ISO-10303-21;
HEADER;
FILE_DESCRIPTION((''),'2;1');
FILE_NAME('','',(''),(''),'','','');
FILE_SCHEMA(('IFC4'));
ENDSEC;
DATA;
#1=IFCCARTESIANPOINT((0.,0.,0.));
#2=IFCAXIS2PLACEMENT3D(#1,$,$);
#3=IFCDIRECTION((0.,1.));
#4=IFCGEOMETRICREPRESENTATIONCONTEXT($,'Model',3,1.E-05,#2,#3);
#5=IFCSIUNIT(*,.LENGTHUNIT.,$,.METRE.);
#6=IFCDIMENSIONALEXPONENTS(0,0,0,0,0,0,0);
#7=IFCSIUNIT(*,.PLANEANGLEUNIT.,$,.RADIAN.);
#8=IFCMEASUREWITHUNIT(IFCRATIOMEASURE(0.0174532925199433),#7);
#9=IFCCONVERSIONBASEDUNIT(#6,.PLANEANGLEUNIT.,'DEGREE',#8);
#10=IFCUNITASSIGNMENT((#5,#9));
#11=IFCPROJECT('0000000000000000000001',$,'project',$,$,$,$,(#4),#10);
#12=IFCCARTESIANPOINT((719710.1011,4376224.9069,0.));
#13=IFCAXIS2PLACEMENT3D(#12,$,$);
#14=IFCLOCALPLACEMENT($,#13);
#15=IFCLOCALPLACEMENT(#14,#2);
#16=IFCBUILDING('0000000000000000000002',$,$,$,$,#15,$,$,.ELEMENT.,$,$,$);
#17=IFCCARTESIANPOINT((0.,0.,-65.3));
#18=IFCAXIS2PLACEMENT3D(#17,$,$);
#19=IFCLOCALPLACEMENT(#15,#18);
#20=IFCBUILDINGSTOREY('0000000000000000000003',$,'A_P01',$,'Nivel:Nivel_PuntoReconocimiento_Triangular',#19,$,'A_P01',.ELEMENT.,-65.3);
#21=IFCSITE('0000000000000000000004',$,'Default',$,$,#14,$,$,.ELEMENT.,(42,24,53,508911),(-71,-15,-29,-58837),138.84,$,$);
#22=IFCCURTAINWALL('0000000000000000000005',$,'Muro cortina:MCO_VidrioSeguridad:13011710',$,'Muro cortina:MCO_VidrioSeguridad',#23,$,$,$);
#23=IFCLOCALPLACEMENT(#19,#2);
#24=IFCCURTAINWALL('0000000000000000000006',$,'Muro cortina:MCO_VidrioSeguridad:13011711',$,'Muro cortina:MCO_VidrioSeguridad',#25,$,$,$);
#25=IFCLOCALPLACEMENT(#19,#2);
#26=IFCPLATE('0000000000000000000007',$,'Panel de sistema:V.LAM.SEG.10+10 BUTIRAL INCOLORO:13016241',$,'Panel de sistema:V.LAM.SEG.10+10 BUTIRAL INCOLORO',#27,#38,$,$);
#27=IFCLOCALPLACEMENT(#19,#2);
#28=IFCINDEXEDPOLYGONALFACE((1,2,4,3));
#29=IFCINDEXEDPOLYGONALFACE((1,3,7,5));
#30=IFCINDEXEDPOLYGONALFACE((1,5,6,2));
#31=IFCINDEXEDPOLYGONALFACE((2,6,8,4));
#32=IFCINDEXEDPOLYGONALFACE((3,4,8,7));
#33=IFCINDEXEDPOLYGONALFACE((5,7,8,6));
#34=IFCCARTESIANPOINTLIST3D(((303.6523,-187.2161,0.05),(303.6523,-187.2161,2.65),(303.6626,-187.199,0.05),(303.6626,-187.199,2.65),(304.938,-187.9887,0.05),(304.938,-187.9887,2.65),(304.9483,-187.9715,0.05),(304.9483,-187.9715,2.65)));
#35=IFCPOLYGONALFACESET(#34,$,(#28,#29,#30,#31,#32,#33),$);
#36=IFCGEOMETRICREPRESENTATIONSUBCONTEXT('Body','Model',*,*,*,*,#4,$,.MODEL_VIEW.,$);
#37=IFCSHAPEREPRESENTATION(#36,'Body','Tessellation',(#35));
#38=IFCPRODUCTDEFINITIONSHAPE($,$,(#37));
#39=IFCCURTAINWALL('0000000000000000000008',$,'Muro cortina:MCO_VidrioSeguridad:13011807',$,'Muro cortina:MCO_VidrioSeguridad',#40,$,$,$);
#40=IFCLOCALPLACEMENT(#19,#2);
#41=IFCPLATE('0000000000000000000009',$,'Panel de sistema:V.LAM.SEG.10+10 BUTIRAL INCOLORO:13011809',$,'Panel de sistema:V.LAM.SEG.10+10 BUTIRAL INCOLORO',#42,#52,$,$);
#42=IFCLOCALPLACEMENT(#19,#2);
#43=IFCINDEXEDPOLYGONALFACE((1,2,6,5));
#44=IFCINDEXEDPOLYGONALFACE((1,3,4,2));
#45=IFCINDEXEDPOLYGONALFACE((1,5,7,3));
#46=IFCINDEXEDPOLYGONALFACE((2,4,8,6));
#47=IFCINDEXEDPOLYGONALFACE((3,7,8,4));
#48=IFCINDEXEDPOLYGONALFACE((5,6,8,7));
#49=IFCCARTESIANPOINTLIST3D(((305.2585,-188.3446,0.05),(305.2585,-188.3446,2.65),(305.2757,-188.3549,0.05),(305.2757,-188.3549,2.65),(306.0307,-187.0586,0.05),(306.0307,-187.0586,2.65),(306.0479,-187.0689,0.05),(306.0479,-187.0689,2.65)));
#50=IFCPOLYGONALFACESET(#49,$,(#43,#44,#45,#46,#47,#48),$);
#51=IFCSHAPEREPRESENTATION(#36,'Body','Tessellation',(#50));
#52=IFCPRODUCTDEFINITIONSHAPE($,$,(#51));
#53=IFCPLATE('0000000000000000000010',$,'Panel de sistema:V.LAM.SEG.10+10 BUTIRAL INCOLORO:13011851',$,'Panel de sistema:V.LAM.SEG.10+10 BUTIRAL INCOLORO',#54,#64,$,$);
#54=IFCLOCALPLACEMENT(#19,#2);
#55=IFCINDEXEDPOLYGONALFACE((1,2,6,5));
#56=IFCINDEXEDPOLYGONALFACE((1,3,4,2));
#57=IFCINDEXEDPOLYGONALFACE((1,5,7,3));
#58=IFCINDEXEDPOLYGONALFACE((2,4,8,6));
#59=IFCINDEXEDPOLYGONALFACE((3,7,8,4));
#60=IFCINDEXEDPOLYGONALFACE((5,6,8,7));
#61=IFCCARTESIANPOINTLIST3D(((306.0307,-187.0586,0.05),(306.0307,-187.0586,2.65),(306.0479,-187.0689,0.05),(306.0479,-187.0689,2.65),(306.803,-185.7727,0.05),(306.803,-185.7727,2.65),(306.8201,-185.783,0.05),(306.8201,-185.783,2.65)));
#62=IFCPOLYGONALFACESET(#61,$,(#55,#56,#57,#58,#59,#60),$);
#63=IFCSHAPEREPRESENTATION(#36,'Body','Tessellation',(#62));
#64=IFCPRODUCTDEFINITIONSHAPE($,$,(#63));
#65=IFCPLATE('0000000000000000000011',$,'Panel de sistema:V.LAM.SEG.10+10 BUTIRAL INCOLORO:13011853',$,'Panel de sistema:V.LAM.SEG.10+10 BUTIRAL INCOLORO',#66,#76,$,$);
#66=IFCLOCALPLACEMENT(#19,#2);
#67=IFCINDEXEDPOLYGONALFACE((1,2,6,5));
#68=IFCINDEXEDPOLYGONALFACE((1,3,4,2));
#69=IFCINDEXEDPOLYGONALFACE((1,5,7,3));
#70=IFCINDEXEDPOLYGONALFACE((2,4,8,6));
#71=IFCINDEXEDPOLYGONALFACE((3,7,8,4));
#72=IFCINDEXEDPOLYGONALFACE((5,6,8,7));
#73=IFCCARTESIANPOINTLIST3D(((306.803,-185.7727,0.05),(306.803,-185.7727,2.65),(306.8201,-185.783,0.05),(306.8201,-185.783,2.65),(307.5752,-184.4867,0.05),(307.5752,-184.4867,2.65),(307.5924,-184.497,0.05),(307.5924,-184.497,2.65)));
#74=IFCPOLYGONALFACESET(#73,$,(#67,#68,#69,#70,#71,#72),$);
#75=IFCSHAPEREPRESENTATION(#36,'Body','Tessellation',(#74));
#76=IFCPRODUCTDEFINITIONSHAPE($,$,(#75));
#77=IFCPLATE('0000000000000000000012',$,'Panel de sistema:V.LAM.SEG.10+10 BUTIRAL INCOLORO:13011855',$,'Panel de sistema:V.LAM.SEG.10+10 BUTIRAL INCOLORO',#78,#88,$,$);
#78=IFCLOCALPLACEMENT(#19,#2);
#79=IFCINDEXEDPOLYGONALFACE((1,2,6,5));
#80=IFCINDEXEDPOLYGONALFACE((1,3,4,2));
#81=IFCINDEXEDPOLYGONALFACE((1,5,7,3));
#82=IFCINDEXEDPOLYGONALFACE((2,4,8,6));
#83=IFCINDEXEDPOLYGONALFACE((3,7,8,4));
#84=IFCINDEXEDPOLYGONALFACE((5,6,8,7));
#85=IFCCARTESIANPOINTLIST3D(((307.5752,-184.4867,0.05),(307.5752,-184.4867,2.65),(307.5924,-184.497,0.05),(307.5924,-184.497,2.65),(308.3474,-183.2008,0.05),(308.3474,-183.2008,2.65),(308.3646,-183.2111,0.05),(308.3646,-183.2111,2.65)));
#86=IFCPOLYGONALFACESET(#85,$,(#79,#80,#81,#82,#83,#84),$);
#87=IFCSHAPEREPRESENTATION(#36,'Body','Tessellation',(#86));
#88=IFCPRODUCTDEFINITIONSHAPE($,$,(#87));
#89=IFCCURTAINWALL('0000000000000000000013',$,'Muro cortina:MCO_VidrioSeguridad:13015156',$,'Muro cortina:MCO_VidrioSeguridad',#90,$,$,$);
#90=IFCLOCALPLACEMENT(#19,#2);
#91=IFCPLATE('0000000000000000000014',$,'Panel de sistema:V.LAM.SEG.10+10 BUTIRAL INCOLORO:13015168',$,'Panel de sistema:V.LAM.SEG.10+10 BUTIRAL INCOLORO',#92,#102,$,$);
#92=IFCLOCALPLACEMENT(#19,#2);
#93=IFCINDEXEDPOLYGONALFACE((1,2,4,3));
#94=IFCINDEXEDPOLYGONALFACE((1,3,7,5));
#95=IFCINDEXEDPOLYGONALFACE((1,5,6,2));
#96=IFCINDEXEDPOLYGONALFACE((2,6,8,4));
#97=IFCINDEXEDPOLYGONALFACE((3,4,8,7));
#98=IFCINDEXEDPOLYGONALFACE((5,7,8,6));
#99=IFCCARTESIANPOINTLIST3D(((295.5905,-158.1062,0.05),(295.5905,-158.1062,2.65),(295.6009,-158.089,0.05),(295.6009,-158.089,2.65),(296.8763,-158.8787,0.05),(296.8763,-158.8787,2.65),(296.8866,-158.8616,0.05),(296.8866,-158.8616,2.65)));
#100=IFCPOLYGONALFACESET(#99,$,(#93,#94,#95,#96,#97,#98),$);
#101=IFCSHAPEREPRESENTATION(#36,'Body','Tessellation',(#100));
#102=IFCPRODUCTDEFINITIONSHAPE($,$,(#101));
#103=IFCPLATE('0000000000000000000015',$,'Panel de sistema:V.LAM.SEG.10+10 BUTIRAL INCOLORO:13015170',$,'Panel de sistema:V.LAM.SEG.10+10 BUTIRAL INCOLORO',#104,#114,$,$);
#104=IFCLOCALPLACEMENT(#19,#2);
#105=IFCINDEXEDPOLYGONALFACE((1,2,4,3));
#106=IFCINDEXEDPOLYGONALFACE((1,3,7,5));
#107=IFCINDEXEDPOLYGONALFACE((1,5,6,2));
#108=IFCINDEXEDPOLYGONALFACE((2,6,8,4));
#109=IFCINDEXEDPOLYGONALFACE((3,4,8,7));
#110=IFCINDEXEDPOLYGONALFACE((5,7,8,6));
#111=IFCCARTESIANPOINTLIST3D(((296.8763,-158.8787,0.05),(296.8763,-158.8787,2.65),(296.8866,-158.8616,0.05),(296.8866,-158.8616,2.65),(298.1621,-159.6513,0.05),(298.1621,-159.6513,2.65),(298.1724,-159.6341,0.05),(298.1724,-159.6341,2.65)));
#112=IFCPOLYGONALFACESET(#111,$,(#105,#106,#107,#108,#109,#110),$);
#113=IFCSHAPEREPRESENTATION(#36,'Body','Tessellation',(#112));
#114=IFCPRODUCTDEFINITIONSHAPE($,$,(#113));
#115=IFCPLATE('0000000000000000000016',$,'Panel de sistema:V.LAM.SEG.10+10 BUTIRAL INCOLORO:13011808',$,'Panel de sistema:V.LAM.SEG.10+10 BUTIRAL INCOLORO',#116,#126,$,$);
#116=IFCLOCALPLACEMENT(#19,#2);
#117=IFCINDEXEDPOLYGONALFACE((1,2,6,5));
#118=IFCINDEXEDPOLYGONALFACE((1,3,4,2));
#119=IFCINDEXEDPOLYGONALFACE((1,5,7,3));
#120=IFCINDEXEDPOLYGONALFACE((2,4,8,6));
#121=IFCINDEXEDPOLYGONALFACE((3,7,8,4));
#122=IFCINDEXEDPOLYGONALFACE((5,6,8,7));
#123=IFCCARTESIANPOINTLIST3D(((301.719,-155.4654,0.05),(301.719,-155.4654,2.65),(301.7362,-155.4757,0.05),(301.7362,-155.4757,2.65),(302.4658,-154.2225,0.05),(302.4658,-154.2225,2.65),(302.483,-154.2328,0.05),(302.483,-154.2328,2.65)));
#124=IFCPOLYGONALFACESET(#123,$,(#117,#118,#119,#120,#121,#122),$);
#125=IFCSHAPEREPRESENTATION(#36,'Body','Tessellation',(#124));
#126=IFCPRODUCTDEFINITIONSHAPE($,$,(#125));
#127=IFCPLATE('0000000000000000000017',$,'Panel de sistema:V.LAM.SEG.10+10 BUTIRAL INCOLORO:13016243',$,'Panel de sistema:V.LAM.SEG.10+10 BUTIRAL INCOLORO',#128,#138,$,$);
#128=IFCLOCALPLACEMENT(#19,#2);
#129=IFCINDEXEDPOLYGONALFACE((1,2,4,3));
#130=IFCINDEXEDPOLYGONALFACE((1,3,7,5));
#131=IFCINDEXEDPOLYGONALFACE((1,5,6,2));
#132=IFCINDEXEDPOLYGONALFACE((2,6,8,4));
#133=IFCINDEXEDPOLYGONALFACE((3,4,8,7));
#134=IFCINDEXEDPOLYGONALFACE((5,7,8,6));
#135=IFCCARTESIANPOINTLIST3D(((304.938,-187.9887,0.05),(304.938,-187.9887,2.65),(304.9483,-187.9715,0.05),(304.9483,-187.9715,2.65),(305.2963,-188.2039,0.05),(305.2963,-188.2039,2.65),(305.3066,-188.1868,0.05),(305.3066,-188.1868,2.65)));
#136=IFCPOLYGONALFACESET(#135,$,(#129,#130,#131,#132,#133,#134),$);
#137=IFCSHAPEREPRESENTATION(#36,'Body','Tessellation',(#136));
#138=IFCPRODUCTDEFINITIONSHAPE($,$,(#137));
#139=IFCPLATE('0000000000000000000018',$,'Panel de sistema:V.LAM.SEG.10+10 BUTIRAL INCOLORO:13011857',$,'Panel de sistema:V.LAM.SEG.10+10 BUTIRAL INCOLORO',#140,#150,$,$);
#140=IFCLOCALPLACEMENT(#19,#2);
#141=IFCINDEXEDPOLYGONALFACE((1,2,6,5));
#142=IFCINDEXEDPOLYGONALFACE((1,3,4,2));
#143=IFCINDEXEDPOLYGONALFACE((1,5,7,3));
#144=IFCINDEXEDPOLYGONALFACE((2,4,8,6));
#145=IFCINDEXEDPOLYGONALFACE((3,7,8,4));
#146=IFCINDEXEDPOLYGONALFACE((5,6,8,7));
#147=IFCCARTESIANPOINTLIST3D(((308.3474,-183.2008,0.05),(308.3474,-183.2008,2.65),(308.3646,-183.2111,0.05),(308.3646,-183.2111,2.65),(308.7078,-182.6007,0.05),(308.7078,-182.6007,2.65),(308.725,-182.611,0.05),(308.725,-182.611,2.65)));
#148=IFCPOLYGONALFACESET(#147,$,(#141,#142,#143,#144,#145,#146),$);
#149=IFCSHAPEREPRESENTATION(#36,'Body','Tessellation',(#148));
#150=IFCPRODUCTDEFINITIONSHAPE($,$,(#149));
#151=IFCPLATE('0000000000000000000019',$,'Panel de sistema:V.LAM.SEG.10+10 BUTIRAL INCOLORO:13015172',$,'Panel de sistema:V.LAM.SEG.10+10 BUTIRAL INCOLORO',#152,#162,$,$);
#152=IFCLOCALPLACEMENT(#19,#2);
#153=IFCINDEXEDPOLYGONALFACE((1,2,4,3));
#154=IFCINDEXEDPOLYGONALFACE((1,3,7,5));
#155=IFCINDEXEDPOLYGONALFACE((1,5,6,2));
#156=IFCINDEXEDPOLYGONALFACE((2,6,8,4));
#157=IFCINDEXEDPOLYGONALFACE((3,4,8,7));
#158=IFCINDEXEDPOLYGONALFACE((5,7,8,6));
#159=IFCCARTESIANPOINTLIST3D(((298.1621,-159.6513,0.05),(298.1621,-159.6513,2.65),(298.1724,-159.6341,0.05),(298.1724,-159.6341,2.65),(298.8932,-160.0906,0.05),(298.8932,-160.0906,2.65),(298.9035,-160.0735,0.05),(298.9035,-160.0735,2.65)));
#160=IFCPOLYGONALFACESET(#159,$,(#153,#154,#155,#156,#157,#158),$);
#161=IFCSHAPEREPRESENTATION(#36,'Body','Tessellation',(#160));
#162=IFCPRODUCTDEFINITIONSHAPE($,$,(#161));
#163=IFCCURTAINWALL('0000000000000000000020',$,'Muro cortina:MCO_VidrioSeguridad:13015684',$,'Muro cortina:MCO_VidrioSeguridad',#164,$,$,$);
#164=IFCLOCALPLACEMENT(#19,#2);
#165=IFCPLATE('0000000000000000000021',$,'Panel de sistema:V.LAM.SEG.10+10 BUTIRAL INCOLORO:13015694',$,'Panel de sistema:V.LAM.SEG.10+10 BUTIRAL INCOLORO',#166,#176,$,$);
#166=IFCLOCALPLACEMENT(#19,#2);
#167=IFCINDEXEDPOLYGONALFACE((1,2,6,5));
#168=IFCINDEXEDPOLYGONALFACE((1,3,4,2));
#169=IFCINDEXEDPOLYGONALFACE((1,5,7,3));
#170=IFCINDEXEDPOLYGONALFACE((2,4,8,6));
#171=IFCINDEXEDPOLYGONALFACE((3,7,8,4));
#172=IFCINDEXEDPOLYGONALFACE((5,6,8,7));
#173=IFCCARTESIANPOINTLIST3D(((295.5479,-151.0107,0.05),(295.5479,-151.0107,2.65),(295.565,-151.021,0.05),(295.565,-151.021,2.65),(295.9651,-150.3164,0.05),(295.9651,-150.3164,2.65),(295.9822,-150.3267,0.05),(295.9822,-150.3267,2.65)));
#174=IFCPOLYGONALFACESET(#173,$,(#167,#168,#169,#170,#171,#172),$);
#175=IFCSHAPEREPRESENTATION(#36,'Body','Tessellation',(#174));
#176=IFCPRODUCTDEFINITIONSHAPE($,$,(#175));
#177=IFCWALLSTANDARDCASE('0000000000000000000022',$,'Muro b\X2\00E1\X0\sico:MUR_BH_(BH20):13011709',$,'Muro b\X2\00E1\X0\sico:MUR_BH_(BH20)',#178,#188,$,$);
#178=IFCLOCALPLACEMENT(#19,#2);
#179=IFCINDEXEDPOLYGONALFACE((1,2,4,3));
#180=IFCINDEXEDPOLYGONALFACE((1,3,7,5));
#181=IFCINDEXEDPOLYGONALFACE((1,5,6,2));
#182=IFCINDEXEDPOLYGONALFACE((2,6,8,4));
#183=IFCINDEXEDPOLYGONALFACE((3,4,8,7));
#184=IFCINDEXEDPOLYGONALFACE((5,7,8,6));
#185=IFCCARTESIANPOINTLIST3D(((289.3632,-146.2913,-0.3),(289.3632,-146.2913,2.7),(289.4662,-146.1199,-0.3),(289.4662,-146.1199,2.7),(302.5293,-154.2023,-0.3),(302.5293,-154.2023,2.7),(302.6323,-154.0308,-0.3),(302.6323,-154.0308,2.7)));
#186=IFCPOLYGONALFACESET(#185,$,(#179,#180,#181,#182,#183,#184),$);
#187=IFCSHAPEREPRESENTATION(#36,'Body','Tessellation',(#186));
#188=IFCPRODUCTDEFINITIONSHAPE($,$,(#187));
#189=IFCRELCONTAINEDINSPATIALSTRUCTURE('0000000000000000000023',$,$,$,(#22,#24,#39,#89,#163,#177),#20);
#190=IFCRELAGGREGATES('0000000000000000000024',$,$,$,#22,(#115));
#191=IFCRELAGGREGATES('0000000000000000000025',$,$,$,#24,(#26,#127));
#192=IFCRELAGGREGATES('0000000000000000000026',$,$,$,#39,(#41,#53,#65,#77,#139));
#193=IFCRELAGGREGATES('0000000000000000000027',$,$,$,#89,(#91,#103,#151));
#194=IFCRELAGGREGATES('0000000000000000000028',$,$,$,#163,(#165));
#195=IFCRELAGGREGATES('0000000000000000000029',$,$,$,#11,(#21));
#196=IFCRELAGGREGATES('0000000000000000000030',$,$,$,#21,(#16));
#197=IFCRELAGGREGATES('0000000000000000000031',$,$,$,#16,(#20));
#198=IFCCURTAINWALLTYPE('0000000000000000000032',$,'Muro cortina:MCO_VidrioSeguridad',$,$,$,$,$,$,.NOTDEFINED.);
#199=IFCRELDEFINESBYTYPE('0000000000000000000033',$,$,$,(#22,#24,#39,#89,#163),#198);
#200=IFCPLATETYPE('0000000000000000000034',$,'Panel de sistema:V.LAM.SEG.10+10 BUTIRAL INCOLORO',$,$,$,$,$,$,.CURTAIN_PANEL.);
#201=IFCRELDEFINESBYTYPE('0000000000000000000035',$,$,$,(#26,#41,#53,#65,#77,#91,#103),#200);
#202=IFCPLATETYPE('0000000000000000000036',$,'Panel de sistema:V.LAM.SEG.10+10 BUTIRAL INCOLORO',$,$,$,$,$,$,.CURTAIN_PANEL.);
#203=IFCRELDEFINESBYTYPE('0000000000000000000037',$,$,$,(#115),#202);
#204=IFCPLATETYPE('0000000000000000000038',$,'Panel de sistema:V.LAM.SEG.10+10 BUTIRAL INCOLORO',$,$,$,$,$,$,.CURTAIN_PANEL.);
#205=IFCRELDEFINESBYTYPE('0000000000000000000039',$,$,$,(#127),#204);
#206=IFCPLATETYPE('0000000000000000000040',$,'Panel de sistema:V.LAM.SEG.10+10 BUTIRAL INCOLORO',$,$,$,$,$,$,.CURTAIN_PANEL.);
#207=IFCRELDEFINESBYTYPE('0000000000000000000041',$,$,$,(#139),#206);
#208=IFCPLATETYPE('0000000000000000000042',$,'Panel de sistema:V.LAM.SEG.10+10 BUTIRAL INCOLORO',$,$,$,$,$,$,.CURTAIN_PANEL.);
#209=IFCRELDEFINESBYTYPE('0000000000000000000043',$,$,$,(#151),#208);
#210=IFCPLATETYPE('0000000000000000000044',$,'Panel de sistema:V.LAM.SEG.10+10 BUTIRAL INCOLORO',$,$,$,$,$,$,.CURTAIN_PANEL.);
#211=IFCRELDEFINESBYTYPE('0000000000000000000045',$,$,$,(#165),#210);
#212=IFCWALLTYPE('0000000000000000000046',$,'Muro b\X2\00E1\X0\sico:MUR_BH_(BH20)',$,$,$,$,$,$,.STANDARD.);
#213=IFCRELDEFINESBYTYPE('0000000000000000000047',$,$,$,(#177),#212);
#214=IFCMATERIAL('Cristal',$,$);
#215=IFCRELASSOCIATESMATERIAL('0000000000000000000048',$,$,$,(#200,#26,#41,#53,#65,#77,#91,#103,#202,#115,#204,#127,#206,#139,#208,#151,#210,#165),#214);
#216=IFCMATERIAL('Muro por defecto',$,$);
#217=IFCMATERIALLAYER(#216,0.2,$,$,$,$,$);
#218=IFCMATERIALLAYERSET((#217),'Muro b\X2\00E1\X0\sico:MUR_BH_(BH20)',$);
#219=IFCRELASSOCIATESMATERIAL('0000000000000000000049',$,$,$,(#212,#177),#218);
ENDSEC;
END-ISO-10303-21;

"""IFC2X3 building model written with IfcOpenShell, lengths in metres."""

from ifc_helpers import new_model, entity, si_unit, converted_unit, direction, frame, frame_2d, origin, origin_2d_with_axis, place, context, subcontext, project, spatial, rectangle, extrude, source, transform, mapped, material, layer, layer_set, layer_usage, type_object, type_shapes, element, aggregate, save


model = new_model("IFC2X3")

# Units and contexts
model_context = context("Model", 3, precision=1e-05, world=origin(), true_north=direction((0.0, 1.0)))
body_context = subcontext(model_context, "Body", "Model", "MODEL_VIEW")
ifc_project = project(units=[si_unit("LENGTHUNIT", "METRE"), converted_unit("PLANEANGLEUNIT", "DEGREE", entity("IfcRatioMeasure", 0.0174532925199433), si_unit("PLANEANGLEUNIT", "RADIAN"), dimensions=[0, 0, 0, 0, 0, 0, 0])], contexts=[model_context])

# Site, building, storey
site_placement = place(None, frame((719710.1011, 4376224.9069, 0.0)))
site = spatial("IfcSite", under=ifc_project, at=site_placement, Name="Default", CompositionType="ELEMENT", RefLatitude=(42, 24, 53, 508911), RefLongitude=(-71, -15, -29, -58837), RefElevation=138.84)
building_placement = place(site_placement, origin())
building = spatial("IfcBuilding", under=site, at=building_placement, CompositionType="ELEMENT")
storey_placement = place(building_placement, frame((0.0, 0.0, -65.3)))
storey = spatial("IfcBuildingStorey", under=building, at=storey_placement, Name="A_P01", ObjectType="Nivel:Nivel_PuntoReconocimiento_Triangular", LongName="A_P01", CompositionType="ELEMENT", Elevation=-65.3)

# Curtain walls, plates
curtain_wall_type = type_object("IfcCurtainWallType", Name="Muro cortina:MCO_VidrioSeguridad", PredefinedType="NOTDEFINED")
curtain_wall_1_placement = place(storey_placement, frame((0.0, 0.0, 65.3)))
curtain_wall_1 = element("IfcCurtainWall", 1, at=curtain_wall_1_placement, inside=storey, type_object=curtain_wall_type, Name="Muro cortina:MCO_VidrioSeguridad:13011710", ObjectType="Muro cortina:MCO_VidrioSeguridad")
ifc_material_1 = material(Name="Cristal")
plate_type_1 = type_object("IfcPlateType", Name="Panel de sistema:V.LAM.SEG.10+10 BUTIRAL INCOLORO", PredefinedType="CURTAIN_PANEL", material=ifc_material_1)
shared_shape_1 = source(origin(), body_context, "Body", "SweptSolid", [
    extrude(rectangle(XDim=0.02, YDim=1.5, at=origin_2d_with_axis()), frame((0.0, 0.0, 0.0), z_axis=(0.0, 0.0, 1.0), x_axis=(0.0, 1.0, 0.0)), (0.0, 0.0, 1.0), 2.6),
])
type_shapes(plate_type_1, [shared_shape_1])
curtain_wall_2_placement = place(storey_placement, frame((0.0, 0.0, 65.3)))
curtain_wall_2 = element("IfcCurtainWall", 2, at=curtain_wall_2_placement, inside=storey, type_object=curtain_wall_type, Name="Muro cortina:MCO_VidrioSeguridad:13011711", ObjectType="Muro cortina:MCO_VidrioSeguridad")
plate_1_placement = place(curtain_wall_2_placement, frame((304.3003, -187.5938, -65.25), z_axis=(0.0, 0.0, 1.0), x_axis=(0.857167, -0.515038, 0.0)))
plate_1 = element("IfcPlate", 3, at=plate_1_placement, type_object=plate_type_1, material=ifc_material_1, Name="Panel de sistema:V.LAM.SEG.10+10 BUTIRAL INCOLORO:13016241", ObjectType="Panel de sistema:V.LAM.SEG.10+10 BUTIRAL INCOLORO", context=body_context, shape_type="MappedRepresentation", body=[
    mapped(shared_shape_1, transform((0.0, 0.0, 0.0), scale=1.0)),
])
curtain_wall_3_placement = place(storey_placement, frame((0.0, 0.0, 65.3)))
curtain_wall_3 = element("IfcCurtainWall", 4, at=curtain_wall_3_placement, inside=storey, type_object=curtain_wall_type, Name="Muro cortina:MCO_VidrioSeguridad:13011807", ObjectType="Muro cortina:MCO_VidrioSeguridad")
plate_2_placement = place(curtain_wall_3_placement, frame((305.6532, -187.7067, -65.25), z_axis=(0.0, 0.0, 1.0), x_axis=(0.514822, 0.857297, 0.0)))
plate_2 = element("IfcPlate", 5, at=plate_2_placement, type_object=plate_type_1, material=ifc_material_1, Name="Panel de sistema:V.LAM.SEG.10+10 BUTIRAL INCOLORO:13011809", ObjectType="Panel de sistema:V.LAM.SEG.10+10 BUTIRAL INCOLORO", context=body_context, shape_type="MappedRepresentation", body=[
    mapped(shared_shape_1, transform((0.0, 0.0, 0.0), scale=1.0)),
])
plate_3_placement = place(curtain_wall_3_placement, frame((306.4254, -186.4208, -65.25), z_axis=(0.0, 0.0, 1.0), x_axis=(0.514822, 0.857297, 0.0)))
plate_3 = element("IfcPlate", 6, at=plate_3_placement, type_object=plate_type_1, material=ifc_material_1, Name="Panel de sistema:V.LAM.SEG.10+10 BUTIRAL INCOLORO:13011851", ObjectType="Panel de sistema:V.LAM.SEG.10+10 BUTIRAL INCOLORO", context=body_context, shape_type="MappedRepresentation", body=[
    mapped(shared_shape_1, transform((0.0, 0.0, 0.0), scale=1.0)),
])
plate_4_placement = place(curtain_wall_3_placement, frame((307.1977, -185.1349, -65.25), z_axis=(0.0, 0.0, 1.0), x_axis=(0.514822, 0.857297, 0.0)))
plate_4 = element("IfcPlate", 7, at=plate_4_placement, type_object=plate_type_1, material=ifc_material_1, Name="Panel de sistema:V.LAM.SEG.10+10 BUTIRAL INCOLORO:13011853", ObjectType="Panel de sistema:V.LAM.SEG.10+10 BUTIRAL INCOLORO", context=body_context, shape_type="MappedRepresentation", body=[
    mapped(shared_shape_1, transform((0.0, 0.0, 0.0), scale=1.0)),
])
plate_5_placement = place(curtain_wall_3_placement, frame((307.9699, -183.8489, -65.25), z_axis=(0.0, 0.0, 1.0), x_axis=(0.514822, 0.857297, 0.0)))
plate_5 = element("IfcPlate", 8, at=plate_5_placement, type_object=plate_type_1, material=ifc_material_1, Name="Panel de sistema:V.LAM.SEG.10+10 BUTIRAL INCOLORO:13011855", ObjectType="Panel de sistema:V.LAM.SEG.10+10 BUTIRAL INCOLORO", context=body_context, shape_type="MappedRepresentation", body=[
    mapped(shared_shape_1, transform((0.0, 0.0, 0.0), scale=1.0)),
])
curtain_wall_4_placement = place(storey_placement, frame((0.0, 0.0, 65.3)))
curtain_wall_4 = element("IfcCurtainWall", 9, at=curtain_wall_4_placement, inside=storey, type_object=curtain_wall_type, Name="Muro cortina:MCO_VidrioSeguridad:13015156", ObjectType="Muro cortina:MCO_VidrioSeguridad")
plate_6_placement = place(curtain_wall_4_placement, frame((296.2386, -158.4839, -65.25), z_axis=(0.0, 0.0, 1.0), x_axis=(0.857167, -0.515038, 0.0)))
plate_6 = element("IfcPlate", 10, at=plate_6_placement, type_object=plate_type_1, material=ifc_material_1, Name="Panel de sistema:V.LAM.SEG.10+10 BUTIRAL INCOLORO:13015168", ObjectType="Panel de sistema:V.LAM.SEG.10+10 BUTIRAL INCOLORO", context=body_context, shape_type="MappedRepresentation", body=[
    mapped(shared_shape_1, transform((0.0, 0.0, 0.0), scale=1.0)),
])
plate_7_placement = place(curtain_wall_4_placement, frame((297.5243, -159.2564, -65.25), z_axis=(0.0, 0.0, 1.0), x_axis=(0.857167, -0.515038, 0.0)))
plate_7 = element("IfcPlate", 11, at=plate_7_placement, type_object=plate_type_1, material=ifc_material_1, Name="Panel de sistema:V.LAM.SEG.10+10 BUTIRAL INCOLORO:13015170", ObjectType="Panel de sistema:V.LAM.SEG.10+10 BUTIRAL INCOLORO", context=body_context, shape_type="MappedRepresentation", body=[
    mapped(shared_shape_1, transform((0.0, 0.0, 0.0), scale=1.0)),
])

# Plates
plate_type_2 = type_object("IfcPlateType", Name="Panel de sistema:V.LAM.SEG.10+10 BUTIRAL INCOLORO", PredefinedType="CURTAIN_PANEL", material=ifc_material_1)
shared_shape_2 = source(origin(), body_context, "Body", "SweptSolid", [
    extrude(rectangle(XDim=0.02, YDim=1.45, at=origin_2d_with_axis()), frame((0.0, 0.0, 0.0), z_axis=(0.0, 0.0, 1.0), x_axis=(0.0, 1.0, 0.0)), (0.0, 0.0, 1.0), 2.6),
])
type_shapes(plate_type_2, [shared_shape_2])
plate_8_placement = place(curtain_wall_1_placement, frame((302.101, -154.8491, -65.25), z_axis=(0.0, 0.0, 1.0), x_axis=(-0.515038, -0.857167, 0.0)))
plate_8 = element("IfcPlate", 12, at=plate_8_placement, type_object=plate_type_2, material=ifc_material_1, Name="Panel de sistema:V.LAM.SEG.10+10 BUTIRAL INCOLORO:13011808", ObjectType="Panel de sistema:V.LAM.SEG.10+10 BUTIRAL INCOLORO", context=body_context, shape_type="MappedRepresentation", body=[
    mapped(shared_shape_2, transform((0.0, 0.0, 0.0), scale=1.0)),
])
aggregate(curtain_wall_1, [plate_8])
plate_type_3 = type_object("IfcPlateType", Name="Panel de sistema:V.LAM.SEG.10+10 BUTIRAL INCOLORO", PredefinedType="CURTAIN_PANEL", material=ifc_material_1)
shared_shape_3 = source(origin(), body_context, "Body", "SweptSolid", [
    extrude(rectangle(XDim=0.02, YDim=0.4179, at=origin_2d_with_axis()), frame((0.0, 0.0, 0.0), z_axis=(0.0, 0.0, 1.0), x_axis=(0.0, 1.0, 0.0)), (0.0, 0.0, 1.0), 2.6),
])
type_shapes(plate_type_3, [shared_shape_3])
plate_9_placement = place(curtain_wall_2_placement, frame((305.1223, -188.0877, -65.25), z_axis=(0.0, 0.0, 1.0), x_axis=(0.857167, -0.515038, 0.0)))
plate_9 = element("IfcPlate", 13, at=plate_9_placement, type_object=plate_type_3, material=ifc_material_1, Name="Panel de sistema:V.LAM.SEG.10+10 BUTIRAL INCOLORO:13016243", ObjectType="Panel de sistema:V.LAM.SEG.10+10 BUTIRAL INCOLORO", context=body_context, shape_type="MappedRepresentation", body=[
    mapped(shared_shape_3, transform((0.0, 0.0, 0.0), scale=1.0)),
])
aggregate(curtain_wall_2, [plate_1, plate_9])
plate_type_4 = type_object("IfcPlateType", Name="Panel de sistema:V.LAM.SEG.10+10 BUTIRAL INCOLORO", PredefinedType="CURTAIN_PANEL", material=ifc_material_1)
shared_shape_4 = source(origin(), body_context, "Body", "SweptSolid", [
    extrude(rectangle(XDim=0.02, YDim=0.7, at=origin_2d_with_axis()), frame((0.0, 0.0, 0.0), z_axis=(0.0, 0.0, 1.0), x_axis=(0.0, 1.0, 0.0)), (0.0, 0.0, 1.0), 2.6),
])
type_shapes(plate_type_4, [shared_shape_4])
plate_10_placement = place(curtain_wall_3_placement, frame((308.5362, -182.9059, -65.25), z_axis=(0.0, 0.0, 1.0), x_axis=(0.514822, 0.857297, 0.0)))
plate_10 = element("IfcPlate", 14, at=plate_10_placement, type_object=plate_type_4, material=ifc_material_1, Name="Panel de sistema:V.LAM.SEG.10+10 BUTIRAL INCOLORO:13011857", ObjectType="Panel de sistema:V.LAM.SEG.10+10 BUTIRAL INCOLORO", context=body_context, shape_type="MappedRepresentation", body=[
    mapped(shared_shape_4, transform((0.0, 0.0, 0.0), scale=1.0)),
])
aggregate(curtain_wall_3, [plate_2, plate_3, plate_4, plate_5, plate_10])
plate_type_5 = type_object("IfcPlateType", Name="Panel de sistema:V.LAM.SEG.10+10 BUTIRAL INCOLORO", PredefinedType="CURTAIN_PANEL", material=ifc_material_1)
shared_shape_5 = source(origin(), body_context, "Body", "SweptSolid", [
    extrude(rectangle(XDim=0.02, YDim=0.853, at=origin_2d_with_axis()), frame((0.0, 0.0, 0.0), z_axis=(0.0, 0.0, 1.0), x_axis=(0.0, 1.0, 0.0)), (0.0, 0.0, 1.0), 2.6),
])
type_shapes(plate_type_5, [shared_shape_5])
plate_11_placement = place(curtain_wall_4_placement, frame((298.5328, -159.8624, -65.25), z_axis=(0.0, 0.0, 1.0), x_axis=(0.857167, -0.515038, 0.0)))
plate_11 = element("IfcPlate", 15, at=plate_11_placement, type_object=plate_type_5, material=ifc_material_1, Name="Panel de sistema:V.LAM.SEG.10+10 BUTIRAL INCOLORO:13015172", ObjectType="Panel de sistema:V.LAM.SEG.10+10 BUTIRAL INCOLORO", context=body_context, shape_type="MappedRepresentation", body=[
    mapped(shared_shape_5, transform((0.0, 0.0, 0.0), scale=1.0)),
])
aggregate(curtain_wall_4, [plate_6, plate_7, plate_11])

# Curtain wall, plate
curtain_wall_5_placement = place(storey_placement, frame((0.0, 0.0, 65.3)))
curtain_wall_5 = element("IfcCurtainWall", 16, at=curtain_wall_5_placement, inside=storey, type_object=curtain_wall_type, Name="Muro cortina:MCO_VidrioSeguridad:13015684", ObjectType="Muro cortina:MCO_VidrioSeguridad")
plate_type_6 = type_object("IfcPlateType", Name="Panel de sistema:V.LAM.SEG.10+10 BUTIRAL INCOLORO", PredefinedType="CURTAIN_PANEL", material=ifc_material_1)
shared_shape_6 = source(origin(), body_context, "Body", "SweptSolid", [
    extrude(rectangle(XDim=0.02, YDim=0.81, at=origin_2d_with_axis()), frame((0.0, 0.0, 0.0), z_axis=(0.0, 0.0, 1.0), x_axis=(0.0, 1.0, 0.0)), (0.0, 0.0, 1.0), 2.6),
])
type_shapes(plate_type_6, [shared_shape_6])
plate_12_placement = place(curtain_wall_5_placement, frame((295.765, -150.6687, -65.25), z_axis=(0.0, 0.0, 1.0), x_axis=(0.515038, 0.857167, 0.0)))
plate_12 = element("IfcPlate", 17, at=plate_12_placement, type_object=plate_type_6, material=ifc_material_1, Name="Panel de sistema:V.LAM.SEG.10+10 BUTIRAL INCOLORO:13015694", ObjectType="Panel de sistema:V.LAM.SEG.10+10 BUTIRAL INCOLORO", context=body_context, shape_type="MappedRepresentation", body=[
    mapped(shared_shape_6, transform((0.0, 0.0, 0.0), scale=1.0)),
])
aggregate(curtain_wall_5, [plate_12])

# Wall
ifc_material_2 = material(Name="Muro por defecto")
ifc_layer = layer(ifc_material_2, 0.2)
ifc_layer_set = layer_set([ifc_layer], Name="Muro básico:MUR_BH_(BH20)")
ifc_layer_usage_1 = layer_usage(ifc_layer_set, "AXIS2", "NEGATIVE", 0.1)
wall_type = type_object("IfcWallType", Name="Muro básico:MUR_BH_(BH20)", PredefinedType="STANDARD", material=ifc_layer_set)
wall_1_placement = place(storey_placement, frame((302.5808, -154.1166, -0.3), z_axis=(0.0, 0.0, 1.0), x_axis=(-0.857167, 0.515038, 0.0)))
element("IfcWallStandardCase", 18, at=wall_1_placement, inside=storey, type_object=wall_type, material=ifc_layer_usage_1, Name="Muro básico:MUR_BH_(BH20):13011709", ObjectType="Muro básico:MUR_BH_(BH20)", context=body_context, shape_type="SweptSolid", body=[
    extrude(rectangle(XDim=15.36, YDim=0.2, at=frame_2d((7.68, 0.0), x_axis=(-1.0, 0.0))), origin(), (0.0, 0.0, 1.0), 3.0),
])

save(model, "model.ifc")
